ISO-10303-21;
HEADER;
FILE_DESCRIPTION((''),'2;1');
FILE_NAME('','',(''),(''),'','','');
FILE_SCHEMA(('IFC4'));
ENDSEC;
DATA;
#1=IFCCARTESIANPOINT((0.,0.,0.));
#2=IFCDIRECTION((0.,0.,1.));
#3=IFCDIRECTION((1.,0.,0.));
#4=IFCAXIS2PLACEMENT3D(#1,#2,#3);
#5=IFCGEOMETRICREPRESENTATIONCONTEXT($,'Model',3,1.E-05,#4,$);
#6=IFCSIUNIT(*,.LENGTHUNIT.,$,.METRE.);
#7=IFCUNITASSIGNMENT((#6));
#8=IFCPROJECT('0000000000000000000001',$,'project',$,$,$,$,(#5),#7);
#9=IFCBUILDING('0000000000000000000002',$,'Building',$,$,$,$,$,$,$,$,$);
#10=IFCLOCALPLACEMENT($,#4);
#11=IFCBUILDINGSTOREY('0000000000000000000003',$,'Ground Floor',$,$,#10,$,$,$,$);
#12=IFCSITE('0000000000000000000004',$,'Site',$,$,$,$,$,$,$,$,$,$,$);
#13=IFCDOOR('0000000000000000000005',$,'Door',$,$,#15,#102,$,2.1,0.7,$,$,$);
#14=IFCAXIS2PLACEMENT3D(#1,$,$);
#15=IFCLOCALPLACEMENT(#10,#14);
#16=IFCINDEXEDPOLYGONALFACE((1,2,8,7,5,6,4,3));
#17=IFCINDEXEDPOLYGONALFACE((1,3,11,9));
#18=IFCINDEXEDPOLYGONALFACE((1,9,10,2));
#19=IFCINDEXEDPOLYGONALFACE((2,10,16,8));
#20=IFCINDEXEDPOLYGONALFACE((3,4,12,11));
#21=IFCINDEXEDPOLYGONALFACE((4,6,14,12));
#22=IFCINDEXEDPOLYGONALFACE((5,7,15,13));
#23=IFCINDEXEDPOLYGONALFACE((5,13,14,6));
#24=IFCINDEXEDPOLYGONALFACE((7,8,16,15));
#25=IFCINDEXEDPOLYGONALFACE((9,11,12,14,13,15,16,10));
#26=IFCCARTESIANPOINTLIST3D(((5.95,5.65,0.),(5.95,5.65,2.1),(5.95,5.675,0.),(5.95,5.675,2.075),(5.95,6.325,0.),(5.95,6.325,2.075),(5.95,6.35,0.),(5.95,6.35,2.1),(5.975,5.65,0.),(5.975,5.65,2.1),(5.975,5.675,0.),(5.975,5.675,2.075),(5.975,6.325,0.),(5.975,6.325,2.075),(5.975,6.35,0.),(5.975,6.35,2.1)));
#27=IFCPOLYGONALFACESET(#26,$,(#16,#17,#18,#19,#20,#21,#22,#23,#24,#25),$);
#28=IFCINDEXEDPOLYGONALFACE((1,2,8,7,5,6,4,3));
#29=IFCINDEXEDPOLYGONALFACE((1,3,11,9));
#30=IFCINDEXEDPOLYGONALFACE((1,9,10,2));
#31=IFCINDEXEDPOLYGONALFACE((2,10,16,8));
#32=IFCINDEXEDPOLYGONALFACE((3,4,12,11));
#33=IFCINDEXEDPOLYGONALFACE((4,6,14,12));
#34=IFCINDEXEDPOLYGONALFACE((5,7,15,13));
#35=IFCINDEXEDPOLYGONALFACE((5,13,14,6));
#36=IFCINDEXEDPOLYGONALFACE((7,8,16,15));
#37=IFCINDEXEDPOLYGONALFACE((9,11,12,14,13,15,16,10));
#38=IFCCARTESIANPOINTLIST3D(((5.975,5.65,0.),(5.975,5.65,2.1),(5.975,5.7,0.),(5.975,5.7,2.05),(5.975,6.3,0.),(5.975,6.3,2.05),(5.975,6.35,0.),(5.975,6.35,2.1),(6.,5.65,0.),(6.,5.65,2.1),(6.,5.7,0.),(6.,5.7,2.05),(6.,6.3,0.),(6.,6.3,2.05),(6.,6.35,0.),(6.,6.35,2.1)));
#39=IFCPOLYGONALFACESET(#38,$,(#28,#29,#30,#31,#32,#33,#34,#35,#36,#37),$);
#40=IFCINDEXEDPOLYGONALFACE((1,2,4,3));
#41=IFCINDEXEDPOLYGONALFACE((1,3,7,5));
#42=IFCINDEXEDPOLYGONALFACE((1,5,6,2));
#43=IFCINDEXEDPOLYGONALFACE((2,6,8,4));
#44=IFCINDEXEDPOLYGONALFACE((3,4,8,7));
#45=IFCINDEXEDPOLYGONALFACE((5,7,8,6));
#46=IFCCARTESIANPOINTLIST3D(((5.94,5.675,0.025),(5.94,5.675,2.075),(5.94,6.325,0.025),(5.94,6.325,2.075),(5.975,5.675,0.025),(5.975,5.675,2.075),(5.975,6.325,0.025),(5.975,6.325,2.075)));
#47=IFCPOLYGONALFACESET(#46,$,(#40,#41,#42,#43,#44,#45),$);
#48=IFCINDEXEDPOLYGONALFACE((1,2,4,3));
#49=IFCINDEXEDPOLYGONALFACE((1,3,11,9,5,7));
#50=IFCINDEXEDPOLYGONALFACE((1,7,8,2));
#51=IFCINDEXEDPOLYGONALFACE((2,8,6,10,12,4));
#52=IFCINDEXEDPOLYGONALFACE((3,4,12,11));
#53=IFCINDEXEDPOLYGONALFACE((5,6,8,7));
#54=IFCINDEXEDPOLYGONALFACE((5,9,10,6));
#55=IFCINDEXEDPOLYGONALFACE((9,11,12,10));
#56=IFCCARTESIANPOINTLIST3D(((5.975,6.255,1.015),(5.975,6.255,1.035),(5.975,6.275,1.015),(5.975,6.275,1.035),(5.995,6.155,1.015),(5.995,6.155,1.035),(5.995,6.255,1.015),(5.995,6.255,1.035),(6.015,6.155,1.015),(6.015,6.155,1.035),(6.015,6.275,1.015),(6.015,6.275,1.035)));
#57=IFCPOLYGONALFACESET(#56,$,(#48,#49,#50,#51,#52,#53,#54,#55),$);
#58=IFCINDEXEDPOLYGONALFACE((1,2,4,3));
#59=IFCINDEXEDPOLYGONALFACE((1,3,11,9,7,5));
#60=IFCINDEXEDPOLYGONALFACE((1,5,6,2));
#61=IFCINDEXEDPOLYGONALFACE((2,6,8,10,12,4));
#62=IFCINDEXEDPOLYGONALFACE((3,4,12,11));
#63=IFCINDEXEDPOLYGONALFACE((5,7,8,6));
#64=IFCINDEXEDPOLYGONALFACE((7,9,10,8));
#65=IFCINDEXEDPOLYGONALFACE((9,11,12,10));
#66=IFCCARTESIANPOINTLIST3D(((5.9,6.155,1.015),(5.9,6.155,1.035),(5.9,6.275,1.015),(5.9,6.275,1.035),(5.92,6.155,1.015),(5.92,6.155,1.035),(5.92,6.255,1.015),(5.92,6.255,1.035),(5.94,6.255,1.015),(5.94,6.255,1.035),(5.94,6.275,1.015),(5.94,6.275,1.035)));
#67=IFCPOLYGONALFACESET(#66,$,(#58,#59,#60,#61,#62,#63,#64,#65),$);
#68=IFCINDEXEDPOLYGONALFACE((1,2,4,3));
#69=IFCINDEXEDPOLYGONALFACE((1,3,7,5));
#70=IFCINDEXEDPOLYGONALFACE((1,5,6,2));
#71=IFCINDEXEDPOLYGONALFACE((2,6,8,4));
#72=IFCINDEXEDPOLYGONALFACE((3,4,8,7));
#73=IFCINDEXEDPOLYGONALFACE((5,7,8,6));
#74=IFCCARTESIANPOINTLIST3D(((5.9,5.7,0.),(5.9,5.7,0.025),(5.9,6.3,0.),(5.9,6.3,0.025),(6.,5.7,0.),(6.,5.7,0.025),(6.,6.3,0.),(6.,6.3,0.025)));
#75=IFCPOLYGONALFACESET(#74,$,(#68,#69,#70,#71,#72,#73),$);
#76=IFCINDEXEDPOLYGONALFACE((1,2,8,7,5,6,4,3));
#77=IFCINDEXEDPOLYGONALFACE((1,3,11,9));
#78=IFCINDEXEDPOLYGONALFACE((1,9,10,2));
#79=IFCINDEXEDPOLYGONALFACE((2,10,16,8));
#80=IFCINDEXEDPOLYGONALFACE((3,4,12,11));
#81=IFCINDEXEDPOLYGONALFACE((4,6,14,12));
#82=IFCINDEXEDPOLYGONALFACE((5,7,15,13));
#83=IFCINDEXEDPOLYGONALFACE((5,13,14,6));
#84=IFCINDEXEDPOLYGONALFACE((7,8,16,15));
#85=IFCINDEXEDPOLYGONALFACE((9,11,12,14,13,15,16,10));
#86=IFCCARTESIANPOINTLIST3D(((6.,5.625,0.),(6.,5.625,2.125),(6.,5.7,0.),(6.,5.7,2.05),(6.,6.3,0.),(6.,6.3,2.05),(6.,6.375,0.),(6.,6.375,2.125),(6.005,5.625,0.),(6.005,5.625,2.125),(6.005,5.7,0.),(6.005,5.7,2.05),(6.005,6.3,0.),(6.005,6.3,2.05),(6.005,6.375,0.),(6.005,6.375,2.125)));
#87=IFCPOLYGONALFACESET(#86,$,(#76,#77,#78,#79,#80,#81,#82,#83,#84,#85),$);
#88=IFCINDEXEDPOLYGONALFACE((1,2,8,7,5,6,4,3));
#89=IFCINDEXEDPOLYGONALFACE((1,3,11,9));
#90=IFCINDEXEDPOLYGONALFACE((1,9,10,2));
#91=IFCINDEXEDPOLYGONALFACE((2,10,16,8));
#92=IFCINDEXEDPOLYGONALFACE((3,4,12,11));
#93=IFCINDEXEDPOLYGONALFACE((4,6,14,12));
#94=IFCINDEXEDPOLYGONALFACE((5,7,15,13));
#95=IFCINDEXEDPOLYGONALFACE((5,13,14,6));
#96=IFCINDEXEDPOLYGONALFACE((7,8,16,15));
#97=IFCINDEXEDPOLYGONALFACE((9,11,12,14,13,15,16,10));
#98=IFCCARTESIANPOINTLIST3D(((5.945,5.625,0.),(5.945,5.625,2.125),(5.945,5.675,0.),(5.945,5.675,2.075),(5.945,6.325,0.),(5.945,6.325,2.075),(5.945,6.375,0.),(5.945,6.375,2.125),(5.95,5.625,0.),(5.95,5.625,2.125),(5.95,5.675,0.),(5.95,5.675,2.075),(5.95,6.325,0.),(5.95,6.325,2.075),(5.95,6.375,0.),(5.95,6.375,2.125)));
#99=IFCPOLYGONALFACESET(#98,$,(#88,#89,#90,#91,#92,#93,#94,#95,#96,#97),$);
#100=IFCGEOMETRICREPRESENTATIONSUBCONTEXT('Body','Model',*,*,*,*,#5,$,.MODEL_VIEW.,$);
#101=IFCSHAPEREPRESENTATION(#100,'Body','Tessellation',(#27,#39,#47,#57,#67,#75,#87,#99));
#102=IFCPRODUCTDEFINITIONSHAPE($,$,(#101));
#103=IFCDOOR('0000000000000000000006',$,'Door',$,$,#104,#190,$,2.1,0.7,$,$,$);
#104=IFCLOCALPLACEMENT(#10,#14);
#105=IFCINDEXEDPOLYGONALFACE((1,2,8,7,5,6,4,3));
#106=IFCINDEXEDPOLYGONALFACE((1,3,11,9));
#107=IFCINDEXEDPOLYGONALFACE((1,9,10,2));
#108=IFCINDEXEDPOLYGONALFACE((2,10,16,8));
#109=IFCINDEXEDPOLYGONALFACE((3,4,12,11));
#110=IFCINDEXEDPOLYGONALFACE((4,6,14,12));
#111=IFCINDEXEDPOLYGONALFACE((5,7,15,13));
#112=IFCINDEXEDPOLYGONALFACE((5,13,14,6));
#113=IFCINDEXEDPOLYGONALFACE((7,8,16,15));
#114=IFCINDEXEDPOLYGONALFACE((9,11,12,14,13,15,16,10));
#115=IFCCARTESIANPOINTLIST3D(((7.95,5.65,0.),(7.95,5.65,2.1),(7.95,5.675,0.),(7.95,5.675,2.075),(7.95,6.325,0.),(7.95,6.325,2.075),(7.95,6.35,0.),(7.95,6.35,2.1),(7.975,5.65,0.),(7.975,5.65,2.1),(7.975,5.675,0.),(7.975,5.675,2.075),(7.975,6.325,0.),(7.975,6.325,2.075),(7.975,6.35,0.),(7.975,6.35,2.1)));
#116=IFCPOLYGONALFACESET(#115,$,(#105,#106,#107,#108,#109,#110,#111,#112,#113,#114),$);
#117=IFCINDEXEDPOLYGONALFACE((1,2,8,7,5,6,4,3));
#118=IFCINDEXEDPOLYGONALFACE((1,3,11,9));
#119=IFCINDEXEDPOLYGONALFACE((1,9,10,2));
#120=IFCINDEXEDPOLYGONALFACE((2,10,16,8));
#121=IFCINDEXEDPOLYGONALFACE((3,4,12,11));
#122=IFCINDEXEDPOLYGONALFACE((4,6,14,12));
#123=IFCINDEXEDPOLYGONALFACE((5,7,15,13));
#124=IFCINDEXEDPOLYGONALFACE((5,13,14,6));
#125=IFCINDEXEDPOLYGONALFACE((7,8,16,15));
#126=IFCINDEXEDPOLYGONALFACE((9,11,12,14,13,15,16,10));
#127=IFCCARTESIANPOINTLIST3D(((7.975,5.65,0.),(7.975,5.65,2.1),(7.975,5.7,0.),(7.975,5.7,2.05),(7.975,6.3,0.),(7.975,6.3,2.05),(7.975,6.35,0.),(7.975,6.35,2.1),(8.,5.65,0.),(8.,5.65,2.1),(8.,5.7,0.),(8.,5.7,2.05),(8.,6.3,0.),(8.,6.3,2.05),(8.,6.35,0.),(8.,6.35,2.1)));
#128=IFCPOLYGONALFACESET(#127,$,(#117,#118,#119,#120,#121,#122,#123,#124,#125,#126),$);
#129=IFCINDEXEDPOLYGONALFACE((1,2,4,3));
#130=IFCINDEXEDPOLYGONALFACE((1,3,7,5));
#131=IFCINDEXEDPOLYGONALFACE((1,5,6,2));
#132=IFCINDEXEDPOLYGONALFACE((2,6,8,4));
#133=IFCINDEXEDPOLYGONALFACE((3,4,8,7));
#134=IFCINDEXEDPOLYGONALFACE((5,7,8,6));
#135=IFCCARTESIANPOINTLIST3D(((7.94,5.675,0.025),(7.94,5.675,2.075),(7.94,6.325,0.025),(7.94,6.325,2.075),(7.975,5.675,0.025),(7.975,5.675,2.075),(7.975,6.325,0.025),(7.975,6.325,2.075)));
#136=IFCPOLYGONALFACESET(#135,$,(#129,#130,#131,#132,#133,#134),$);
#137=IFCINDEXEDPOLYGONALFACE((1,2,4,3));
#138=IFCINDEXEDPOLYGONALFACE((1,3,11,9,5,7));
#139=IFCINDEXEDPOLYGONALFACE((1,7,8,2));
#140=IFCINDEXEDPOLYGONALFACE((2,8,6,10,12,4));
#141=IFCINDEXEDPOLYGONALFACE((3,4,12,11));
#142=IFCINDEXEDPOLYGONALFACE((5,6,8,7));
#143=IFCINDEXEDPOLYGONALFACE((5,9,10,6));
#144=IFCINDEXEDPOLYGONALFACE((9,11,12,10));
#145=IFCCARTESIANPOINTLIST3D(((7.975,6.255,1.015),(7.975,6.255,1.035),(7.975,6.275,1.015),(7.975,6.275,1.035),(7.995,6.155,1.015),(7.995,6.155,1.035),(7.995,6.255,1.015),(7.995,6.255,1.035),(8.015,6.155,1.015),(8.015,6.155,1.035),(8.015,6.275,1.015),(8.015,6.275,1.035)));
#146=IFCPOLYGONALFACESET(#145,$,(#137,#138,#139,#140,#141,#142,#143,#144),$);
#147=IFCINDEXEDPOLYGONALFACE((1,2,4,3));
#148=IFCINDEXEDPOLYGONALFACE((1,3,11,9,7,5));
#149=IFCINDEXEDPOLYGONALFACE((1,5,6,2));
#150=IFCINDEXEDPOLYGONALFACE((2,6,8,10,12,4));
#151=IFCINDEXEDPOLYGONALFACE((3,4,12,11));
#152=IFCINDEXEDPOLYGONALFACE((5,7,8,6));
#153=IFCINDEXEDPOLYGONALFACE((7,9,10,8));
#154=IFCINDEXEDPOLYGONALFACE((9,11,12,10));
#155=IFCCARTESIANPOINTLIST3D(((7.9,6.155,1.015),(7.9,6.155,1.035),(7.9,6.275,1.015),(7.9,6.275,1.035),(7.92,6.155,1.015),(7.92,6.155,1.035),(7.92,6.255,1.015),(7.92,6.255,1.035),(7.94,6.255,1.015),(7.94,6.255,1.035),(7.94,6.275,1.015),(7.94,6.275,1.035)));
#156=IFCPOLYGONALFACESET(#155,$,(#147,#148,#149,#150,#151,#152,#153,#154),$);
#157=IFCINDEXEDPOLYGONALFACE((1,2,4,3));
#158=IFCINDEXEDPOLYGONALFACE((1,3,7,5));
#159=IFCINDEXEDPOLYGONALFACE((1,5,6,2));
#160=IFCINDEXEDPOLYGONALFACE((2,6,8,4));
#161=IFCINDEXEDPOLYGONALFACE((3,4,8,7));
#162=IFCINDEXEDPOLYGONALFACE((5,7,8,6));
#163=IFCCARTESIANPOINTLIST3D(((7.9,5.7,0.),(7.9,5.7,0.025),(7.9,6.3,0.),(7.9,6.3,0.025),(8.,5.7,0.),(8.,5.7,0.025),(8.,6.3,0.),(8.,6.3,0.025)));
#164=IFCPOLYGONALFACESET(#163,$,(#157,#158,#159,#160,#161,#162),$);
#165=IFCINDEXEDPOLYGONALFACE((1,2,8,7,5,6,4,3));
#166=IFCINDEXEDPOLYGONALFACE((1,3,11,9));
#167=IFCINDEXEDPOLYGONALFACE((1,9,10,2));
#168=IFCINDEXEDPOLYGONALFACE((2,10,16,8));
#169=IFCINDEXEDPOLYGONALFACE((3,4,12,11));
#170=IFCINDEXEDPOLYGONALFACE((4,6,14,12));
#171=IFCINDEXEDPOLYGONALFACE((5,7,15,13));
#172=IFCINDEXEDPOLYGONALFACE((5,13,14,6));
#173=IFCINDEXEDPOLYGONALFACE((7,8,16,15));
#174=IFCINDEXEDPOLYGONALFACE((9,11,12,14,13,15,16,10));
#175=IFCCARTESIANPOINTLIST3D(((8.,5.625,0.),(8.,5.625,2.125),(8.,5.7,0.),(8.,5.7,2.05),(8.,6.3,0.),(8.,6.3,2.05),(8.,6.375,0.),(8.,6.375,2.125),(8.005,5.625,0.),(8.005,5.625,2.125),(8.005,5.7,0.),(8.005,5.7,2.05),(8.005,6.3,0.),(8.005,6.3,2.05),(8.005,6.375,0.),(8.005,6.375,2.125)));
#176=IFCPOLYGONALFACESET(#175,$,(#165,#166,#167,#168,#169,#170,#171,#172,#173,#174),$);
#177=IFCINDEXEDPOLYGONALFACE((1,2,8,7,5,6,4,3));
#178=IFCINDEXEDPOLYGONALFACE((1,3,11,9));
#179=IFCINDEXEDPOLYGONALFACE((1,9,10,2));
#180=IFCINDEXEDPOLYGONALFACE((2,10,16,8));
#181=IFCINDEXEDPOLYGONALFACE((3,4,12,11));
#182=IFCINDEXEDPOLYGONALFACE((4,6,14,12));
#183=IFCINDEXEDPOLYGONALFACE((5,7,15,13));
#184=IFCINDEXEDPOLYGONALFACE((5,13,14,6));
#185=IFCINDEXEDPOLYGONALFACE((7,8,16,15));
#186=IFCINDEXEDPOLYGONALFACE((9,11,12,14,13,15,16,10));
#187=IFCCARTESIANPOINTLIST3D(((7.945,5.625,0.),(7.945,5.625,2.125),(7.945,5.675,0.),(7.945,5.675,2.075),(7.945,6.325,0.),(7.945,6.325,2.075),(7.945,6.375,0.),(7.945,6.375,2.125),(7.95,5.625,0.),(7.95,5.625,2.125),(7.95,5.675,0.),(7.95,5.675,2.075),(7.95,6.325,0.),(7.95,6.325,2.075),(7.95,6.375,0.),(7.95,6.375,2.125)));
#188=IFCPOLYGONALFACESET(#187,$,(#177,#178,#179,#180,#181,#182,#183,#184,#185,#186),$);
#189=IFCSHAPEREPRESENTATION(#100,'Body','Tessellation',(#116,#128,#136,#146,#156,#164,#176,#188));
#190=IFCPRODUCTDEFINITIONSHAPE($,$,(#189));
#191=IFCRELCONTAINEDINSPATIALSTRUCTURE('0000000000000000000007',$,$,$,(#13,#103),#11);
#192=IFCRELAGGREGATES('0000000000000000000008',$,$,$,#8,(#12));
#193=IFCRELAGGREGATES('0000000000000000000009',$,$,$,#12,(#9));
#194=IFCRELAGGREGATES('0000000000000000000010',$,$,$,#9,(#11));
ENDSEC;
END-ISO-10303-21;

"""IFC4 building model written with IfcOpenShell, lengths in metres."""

from ifc_helpers import new_model, si_unit, frame, origin_with_axes, place, context, subcontext, project, spatial, line, indexed_curve, outline, extrude, element, save


model = new_model("IFC4")

# Units and contexts
model_context = context("Model", 3, precision=1e-05, world=origin_with_axes())
body_context = subcontext(model_context, "Body", "Model", "MODEL_VIEW")
ifc_project = project(units=[si_unit("LENGTHUNIT", "METRE")], contexts=[model_context])

# Site, building, storey
site = spatial("IfcSite", under=ifc_project, Name="Site")
building = spatial("IfcBuilding", under=site, Name="Building")
storey_placement = place(None, origin_with_axes())
storey = spatial("IfcBuildingStorey", under=building, at=storey_placement, Name="Ground Floor")

# Doors
door_1_placement = place(storey_placement, frame((6.0, 5.65, 0.0), z_axis=(0.0, 0.0, 1.0), x_axis=(0.0, 1.0, 0.0)))
element("IfcDoor", 1, at=door_1_placement, inside=storey, Name="Door", OverallHeight=2.1, OverallWidth=0.7, context=body_context, shape_type="SweptSolid", body=[
    extrude(outline(indexed_curve([(0.0, 0.0), (0.0, 2.1), (0.7, 2.1), (0.7, 0.0), (0.675, 0.0), (0.675, 2.075), (0.025, 2.075), (0.025, 0.0)], segments=[line(1, 2, 3, 4, 5, 6, 7, 8, 1)])), frame((0.0, 0.025, 0.0), z_axis=(0.0, -1.0, 0.0), x_axis=(1.0, 0.0, 0.0)), (0.0, 0.0, -1.0), 0.025),
    extrude(outline(indexed_curve([(0.0, 0.0), (0.0, 2.1), (0.7, 2.1), (0.7, 0.0), (0.65, 0.0), (0.65, 2.05), (0.05, 2.05), (0.05, 0.0)], segments=[line(1, 2, 3, 4, 5, 6, 7, 8, 1)])), frame((0.0, 0.0, 0.0), z_axis=(0.0, -1.0, 0.0), x_axis=(1.0, 0.0, 0.0)), (0.0, 0.0, -1.0), 0.025),
    extrude(outline(indexed_curve([(0.0, 0.0), (0.65, 0.0), (0.65, 0.035), (0.0, 0.035)], segments=[line(1, 2, 3, 4, 1)])), frame((0.025, 0.025, 0.025), z_axis=(0.0, 0.0, 1.0), x_axis=(1.0, 0.0, 0.0)), (0.0, 0.0, 1.0), 2.05),
    extrude(outline(indexed_curve([(0.0, 0.0), (0.0, -0.04), (-0.12, -0.04), (-0.12, -0.02), (-0.02, -0.02), (-0.02, 0.0)], segments=[line(1, 2, 3, 4, 5, 6, 1)])), frame((0.625, 0.025, 1.015), z_axis=(0.0, 0.0, 1.0), x_axis=(1.0, 0.0, 0.0)), (0.0, 0.0, 1.0), 0.02),
    extrude(outline(indexed_curve([(0.0, 0.0), (0.0, 0.04), (-0.12, 0.04), (-0.12, 0.02), (-0.02, 0.02), (-0.02, 0.0)], segments=[line(1, 2, 3, 4, 5, 6, 1)])), frame((0.625, 0.06, 1.015), z_axis=(0.0, 0.0, 1.0), x_axis=(1.0, 0.0, 0.0)), (0.0, 0.0, 1.0), 0.02),
    extrude(outline(indexed_curve([(0.0, 0.0), (0.6, 0.0), (0.6, 0.1), (0.0, 0.1)], segments=[line(1, 2, 3, 4, 1)])), frame((0.05, 0.0, 0.0), z_axis=(0.0, 0.0, 1.0), x_axis=(1.0, 0.0, 0.0)), (0.0, 0.0, 1.0), 0.025),
    extrude(outline(indexed_curve([(0.0, 0.0), (0.0, 2.125), (0.75, 2.125), (0.75, 0.0), (0.675, 0.0), (0.675, 2.05), (0.075, 2.05), (0.075, 0.0)], segments=[line(1, 2, 3, 4, 5, 6, 7, 8, 1)])), frame((-0.025, -0.005, 0.0), z_axis=(0.0, -1.0, 0.0), x_axis=(1.0, 0.0, 0.0)), (0.0, 0.0, -1.0), 0.005),
    extrude(outline(indexed_curve([(0.0, 0.0), (0.0, 2.125), (0.75, 2.125), (0.75, 0.0), (0.7, 0.0), (0.7, 2.075), (0.05, 2.075), (0.05, 0.0)], segments=[line(1, 2, 3, 4, 5, 6, 7, 8, 1)])), frame((-0.025, 0.05, 0.0), z_axis=(0.0, -1.0, 0.0), x_axis=(1.0, 0.0, 0.0)), (0.0, 0.0, -1.0), 0.005),
])
door_2_placement = place(storey_placement, frame((8.0, 5.65, 0.0), z_axis=(0.0, 0.0, 1.0), x_axis=(0.0, 1.0, 0.0)))
element("IfcDoor", 2, at=door_2_placement, inside=storey, Name="Door", OverallHeight=2.1, OverallWidth=0.7, context=body_context, shape_type="SweptSolid", body=[
    extrude(outline(indexed_curve([(0.0, 0.0), (0.0, 2.1), (0.7, 2.1), (0.7, 0.0), (0.675, 0.0), (0.675, 2.075), (0.025, 2.075), (0.025, 0.0)], segments=[line(1, 2, 3, 4, 5, 6, 7, 8, 1)])), frame((0.0, 0.025, 0.0), z_axis=(0.0, -1.0, 0.0), x_axis=(1.0, 0.0, 0.0)), (0.0, 0.0, -1.0), 0.025),
    extrude(outline(indexed_curve([(0.0, 0.0), (0.0, 2.1), (0.7, 2.1), (0.7, 0.0), (0.65, 0.0), (0.65, 2.05), (0.05, 2.05), (0.05, 0.0)], segments=[line(1, 2, 3, 4, 5, 6, 7, 8, 1)])), frame((0.0, 0.0, 0.0), z_axis=(0.0, -1.0, 0.0), x_axis=(1.0, 0.0, 0.0)), (0.0, 0.0, -1.0), 0.025),
    extrude(outline(indexed_curve([(0.0, 0.0), (0.65, 0.0), (0.65, 0.035), (0.0, 0.035)], segments=[line(1, 2, 3, 4, 1)])), frame((0.025, 0.025, 0.025), z_axis=(0.0, 0.0, 1.0), x_axis=(1.0, 0.0, 0.0)), (0.0, 0.0, 1.0), 2.05),
    extrude(outline(indexed_curve([(0.0, 0.0), (0.0, -0.04), (-0.12, -0.04), (-0.12, -0.02), (-0.02, -0.02), (-0.02, 0.0)], segments=[line(1, 2, 3, 4, 5, 6, 1)])), frame((0.625, 0.025, 1.015), z_axis=(0.0, 0.0, 1.0), x_axis=(1.0, 0.0, 0.0)), (0.0, 0.0, 1.0), 0.02),
    extrude(outline(indexed_curve([(0.0, 0.0), (0.0, 0.04), (-0.12, 0.04), (-0.12, 0.02), (-0.02, 0.02), (-0.02, 0.0)], segments=[line(1, 2, 3, 4, 5, 6, 1)])), frame((0.625, 0.06, 1.015), z_axis=(0.0, 0.0, 1.0), x_axis=(1.0, 0.0, 0.0)), (0.0, 0.0, 1.0), 0.02),
    extrude(outline(indexed_curve([(0.0, 0.0), (0.6, 0.0), (0.6, 0.1), (0.0, 0.1)], segments=[line(1, 2, 3, 4, 1)])), frame((0.05, 0.0, 0.0), z_axis=(0.0, 0.0, 1.0), x_axis=(1.0, 0.0, 0.0)), (0.0, 0.0, 1.0), 0.025),
    extrude(outline(indexed_curve([(0.0, 0.0), (0.0, 2.125), (0.75, 2.125), (0.75, 0.0), (0.675, 0.0), (0.675, 2.05), (0.075, 2.05), (0.075, 0.0)], segments=[line(1, 2, 3, 4, 5, 6, 7, 8, 1)])), frame((-0.025, -0.005, 0.0), z_axis=(0.0, -1.0, 0.0), x_axis=(1.0, 0.0, 0.0)), (0.0, 0.0, -1.0), 0.005),
    extrude(outline(indexed_curve([(0.0, 0.0), (0.0, 2.125), (0.75, 2.125), (0.75, 0.0), (0.7, 0.0), (0.7, 2.075), (0.05, 2.075), (0.05, 0.0)], segments=[line(1, 2, 3, 4, 5, 6, 7, 8, 1)])), frame((-0.025, 0.05, 0.0), z_axis=(0.0, -1.0, 0.0), x_axis=(1.0, 0.0, 0.0)), (0.0, 0.0, -1.0), 0.005),
])

save(model, "model.ifc")
